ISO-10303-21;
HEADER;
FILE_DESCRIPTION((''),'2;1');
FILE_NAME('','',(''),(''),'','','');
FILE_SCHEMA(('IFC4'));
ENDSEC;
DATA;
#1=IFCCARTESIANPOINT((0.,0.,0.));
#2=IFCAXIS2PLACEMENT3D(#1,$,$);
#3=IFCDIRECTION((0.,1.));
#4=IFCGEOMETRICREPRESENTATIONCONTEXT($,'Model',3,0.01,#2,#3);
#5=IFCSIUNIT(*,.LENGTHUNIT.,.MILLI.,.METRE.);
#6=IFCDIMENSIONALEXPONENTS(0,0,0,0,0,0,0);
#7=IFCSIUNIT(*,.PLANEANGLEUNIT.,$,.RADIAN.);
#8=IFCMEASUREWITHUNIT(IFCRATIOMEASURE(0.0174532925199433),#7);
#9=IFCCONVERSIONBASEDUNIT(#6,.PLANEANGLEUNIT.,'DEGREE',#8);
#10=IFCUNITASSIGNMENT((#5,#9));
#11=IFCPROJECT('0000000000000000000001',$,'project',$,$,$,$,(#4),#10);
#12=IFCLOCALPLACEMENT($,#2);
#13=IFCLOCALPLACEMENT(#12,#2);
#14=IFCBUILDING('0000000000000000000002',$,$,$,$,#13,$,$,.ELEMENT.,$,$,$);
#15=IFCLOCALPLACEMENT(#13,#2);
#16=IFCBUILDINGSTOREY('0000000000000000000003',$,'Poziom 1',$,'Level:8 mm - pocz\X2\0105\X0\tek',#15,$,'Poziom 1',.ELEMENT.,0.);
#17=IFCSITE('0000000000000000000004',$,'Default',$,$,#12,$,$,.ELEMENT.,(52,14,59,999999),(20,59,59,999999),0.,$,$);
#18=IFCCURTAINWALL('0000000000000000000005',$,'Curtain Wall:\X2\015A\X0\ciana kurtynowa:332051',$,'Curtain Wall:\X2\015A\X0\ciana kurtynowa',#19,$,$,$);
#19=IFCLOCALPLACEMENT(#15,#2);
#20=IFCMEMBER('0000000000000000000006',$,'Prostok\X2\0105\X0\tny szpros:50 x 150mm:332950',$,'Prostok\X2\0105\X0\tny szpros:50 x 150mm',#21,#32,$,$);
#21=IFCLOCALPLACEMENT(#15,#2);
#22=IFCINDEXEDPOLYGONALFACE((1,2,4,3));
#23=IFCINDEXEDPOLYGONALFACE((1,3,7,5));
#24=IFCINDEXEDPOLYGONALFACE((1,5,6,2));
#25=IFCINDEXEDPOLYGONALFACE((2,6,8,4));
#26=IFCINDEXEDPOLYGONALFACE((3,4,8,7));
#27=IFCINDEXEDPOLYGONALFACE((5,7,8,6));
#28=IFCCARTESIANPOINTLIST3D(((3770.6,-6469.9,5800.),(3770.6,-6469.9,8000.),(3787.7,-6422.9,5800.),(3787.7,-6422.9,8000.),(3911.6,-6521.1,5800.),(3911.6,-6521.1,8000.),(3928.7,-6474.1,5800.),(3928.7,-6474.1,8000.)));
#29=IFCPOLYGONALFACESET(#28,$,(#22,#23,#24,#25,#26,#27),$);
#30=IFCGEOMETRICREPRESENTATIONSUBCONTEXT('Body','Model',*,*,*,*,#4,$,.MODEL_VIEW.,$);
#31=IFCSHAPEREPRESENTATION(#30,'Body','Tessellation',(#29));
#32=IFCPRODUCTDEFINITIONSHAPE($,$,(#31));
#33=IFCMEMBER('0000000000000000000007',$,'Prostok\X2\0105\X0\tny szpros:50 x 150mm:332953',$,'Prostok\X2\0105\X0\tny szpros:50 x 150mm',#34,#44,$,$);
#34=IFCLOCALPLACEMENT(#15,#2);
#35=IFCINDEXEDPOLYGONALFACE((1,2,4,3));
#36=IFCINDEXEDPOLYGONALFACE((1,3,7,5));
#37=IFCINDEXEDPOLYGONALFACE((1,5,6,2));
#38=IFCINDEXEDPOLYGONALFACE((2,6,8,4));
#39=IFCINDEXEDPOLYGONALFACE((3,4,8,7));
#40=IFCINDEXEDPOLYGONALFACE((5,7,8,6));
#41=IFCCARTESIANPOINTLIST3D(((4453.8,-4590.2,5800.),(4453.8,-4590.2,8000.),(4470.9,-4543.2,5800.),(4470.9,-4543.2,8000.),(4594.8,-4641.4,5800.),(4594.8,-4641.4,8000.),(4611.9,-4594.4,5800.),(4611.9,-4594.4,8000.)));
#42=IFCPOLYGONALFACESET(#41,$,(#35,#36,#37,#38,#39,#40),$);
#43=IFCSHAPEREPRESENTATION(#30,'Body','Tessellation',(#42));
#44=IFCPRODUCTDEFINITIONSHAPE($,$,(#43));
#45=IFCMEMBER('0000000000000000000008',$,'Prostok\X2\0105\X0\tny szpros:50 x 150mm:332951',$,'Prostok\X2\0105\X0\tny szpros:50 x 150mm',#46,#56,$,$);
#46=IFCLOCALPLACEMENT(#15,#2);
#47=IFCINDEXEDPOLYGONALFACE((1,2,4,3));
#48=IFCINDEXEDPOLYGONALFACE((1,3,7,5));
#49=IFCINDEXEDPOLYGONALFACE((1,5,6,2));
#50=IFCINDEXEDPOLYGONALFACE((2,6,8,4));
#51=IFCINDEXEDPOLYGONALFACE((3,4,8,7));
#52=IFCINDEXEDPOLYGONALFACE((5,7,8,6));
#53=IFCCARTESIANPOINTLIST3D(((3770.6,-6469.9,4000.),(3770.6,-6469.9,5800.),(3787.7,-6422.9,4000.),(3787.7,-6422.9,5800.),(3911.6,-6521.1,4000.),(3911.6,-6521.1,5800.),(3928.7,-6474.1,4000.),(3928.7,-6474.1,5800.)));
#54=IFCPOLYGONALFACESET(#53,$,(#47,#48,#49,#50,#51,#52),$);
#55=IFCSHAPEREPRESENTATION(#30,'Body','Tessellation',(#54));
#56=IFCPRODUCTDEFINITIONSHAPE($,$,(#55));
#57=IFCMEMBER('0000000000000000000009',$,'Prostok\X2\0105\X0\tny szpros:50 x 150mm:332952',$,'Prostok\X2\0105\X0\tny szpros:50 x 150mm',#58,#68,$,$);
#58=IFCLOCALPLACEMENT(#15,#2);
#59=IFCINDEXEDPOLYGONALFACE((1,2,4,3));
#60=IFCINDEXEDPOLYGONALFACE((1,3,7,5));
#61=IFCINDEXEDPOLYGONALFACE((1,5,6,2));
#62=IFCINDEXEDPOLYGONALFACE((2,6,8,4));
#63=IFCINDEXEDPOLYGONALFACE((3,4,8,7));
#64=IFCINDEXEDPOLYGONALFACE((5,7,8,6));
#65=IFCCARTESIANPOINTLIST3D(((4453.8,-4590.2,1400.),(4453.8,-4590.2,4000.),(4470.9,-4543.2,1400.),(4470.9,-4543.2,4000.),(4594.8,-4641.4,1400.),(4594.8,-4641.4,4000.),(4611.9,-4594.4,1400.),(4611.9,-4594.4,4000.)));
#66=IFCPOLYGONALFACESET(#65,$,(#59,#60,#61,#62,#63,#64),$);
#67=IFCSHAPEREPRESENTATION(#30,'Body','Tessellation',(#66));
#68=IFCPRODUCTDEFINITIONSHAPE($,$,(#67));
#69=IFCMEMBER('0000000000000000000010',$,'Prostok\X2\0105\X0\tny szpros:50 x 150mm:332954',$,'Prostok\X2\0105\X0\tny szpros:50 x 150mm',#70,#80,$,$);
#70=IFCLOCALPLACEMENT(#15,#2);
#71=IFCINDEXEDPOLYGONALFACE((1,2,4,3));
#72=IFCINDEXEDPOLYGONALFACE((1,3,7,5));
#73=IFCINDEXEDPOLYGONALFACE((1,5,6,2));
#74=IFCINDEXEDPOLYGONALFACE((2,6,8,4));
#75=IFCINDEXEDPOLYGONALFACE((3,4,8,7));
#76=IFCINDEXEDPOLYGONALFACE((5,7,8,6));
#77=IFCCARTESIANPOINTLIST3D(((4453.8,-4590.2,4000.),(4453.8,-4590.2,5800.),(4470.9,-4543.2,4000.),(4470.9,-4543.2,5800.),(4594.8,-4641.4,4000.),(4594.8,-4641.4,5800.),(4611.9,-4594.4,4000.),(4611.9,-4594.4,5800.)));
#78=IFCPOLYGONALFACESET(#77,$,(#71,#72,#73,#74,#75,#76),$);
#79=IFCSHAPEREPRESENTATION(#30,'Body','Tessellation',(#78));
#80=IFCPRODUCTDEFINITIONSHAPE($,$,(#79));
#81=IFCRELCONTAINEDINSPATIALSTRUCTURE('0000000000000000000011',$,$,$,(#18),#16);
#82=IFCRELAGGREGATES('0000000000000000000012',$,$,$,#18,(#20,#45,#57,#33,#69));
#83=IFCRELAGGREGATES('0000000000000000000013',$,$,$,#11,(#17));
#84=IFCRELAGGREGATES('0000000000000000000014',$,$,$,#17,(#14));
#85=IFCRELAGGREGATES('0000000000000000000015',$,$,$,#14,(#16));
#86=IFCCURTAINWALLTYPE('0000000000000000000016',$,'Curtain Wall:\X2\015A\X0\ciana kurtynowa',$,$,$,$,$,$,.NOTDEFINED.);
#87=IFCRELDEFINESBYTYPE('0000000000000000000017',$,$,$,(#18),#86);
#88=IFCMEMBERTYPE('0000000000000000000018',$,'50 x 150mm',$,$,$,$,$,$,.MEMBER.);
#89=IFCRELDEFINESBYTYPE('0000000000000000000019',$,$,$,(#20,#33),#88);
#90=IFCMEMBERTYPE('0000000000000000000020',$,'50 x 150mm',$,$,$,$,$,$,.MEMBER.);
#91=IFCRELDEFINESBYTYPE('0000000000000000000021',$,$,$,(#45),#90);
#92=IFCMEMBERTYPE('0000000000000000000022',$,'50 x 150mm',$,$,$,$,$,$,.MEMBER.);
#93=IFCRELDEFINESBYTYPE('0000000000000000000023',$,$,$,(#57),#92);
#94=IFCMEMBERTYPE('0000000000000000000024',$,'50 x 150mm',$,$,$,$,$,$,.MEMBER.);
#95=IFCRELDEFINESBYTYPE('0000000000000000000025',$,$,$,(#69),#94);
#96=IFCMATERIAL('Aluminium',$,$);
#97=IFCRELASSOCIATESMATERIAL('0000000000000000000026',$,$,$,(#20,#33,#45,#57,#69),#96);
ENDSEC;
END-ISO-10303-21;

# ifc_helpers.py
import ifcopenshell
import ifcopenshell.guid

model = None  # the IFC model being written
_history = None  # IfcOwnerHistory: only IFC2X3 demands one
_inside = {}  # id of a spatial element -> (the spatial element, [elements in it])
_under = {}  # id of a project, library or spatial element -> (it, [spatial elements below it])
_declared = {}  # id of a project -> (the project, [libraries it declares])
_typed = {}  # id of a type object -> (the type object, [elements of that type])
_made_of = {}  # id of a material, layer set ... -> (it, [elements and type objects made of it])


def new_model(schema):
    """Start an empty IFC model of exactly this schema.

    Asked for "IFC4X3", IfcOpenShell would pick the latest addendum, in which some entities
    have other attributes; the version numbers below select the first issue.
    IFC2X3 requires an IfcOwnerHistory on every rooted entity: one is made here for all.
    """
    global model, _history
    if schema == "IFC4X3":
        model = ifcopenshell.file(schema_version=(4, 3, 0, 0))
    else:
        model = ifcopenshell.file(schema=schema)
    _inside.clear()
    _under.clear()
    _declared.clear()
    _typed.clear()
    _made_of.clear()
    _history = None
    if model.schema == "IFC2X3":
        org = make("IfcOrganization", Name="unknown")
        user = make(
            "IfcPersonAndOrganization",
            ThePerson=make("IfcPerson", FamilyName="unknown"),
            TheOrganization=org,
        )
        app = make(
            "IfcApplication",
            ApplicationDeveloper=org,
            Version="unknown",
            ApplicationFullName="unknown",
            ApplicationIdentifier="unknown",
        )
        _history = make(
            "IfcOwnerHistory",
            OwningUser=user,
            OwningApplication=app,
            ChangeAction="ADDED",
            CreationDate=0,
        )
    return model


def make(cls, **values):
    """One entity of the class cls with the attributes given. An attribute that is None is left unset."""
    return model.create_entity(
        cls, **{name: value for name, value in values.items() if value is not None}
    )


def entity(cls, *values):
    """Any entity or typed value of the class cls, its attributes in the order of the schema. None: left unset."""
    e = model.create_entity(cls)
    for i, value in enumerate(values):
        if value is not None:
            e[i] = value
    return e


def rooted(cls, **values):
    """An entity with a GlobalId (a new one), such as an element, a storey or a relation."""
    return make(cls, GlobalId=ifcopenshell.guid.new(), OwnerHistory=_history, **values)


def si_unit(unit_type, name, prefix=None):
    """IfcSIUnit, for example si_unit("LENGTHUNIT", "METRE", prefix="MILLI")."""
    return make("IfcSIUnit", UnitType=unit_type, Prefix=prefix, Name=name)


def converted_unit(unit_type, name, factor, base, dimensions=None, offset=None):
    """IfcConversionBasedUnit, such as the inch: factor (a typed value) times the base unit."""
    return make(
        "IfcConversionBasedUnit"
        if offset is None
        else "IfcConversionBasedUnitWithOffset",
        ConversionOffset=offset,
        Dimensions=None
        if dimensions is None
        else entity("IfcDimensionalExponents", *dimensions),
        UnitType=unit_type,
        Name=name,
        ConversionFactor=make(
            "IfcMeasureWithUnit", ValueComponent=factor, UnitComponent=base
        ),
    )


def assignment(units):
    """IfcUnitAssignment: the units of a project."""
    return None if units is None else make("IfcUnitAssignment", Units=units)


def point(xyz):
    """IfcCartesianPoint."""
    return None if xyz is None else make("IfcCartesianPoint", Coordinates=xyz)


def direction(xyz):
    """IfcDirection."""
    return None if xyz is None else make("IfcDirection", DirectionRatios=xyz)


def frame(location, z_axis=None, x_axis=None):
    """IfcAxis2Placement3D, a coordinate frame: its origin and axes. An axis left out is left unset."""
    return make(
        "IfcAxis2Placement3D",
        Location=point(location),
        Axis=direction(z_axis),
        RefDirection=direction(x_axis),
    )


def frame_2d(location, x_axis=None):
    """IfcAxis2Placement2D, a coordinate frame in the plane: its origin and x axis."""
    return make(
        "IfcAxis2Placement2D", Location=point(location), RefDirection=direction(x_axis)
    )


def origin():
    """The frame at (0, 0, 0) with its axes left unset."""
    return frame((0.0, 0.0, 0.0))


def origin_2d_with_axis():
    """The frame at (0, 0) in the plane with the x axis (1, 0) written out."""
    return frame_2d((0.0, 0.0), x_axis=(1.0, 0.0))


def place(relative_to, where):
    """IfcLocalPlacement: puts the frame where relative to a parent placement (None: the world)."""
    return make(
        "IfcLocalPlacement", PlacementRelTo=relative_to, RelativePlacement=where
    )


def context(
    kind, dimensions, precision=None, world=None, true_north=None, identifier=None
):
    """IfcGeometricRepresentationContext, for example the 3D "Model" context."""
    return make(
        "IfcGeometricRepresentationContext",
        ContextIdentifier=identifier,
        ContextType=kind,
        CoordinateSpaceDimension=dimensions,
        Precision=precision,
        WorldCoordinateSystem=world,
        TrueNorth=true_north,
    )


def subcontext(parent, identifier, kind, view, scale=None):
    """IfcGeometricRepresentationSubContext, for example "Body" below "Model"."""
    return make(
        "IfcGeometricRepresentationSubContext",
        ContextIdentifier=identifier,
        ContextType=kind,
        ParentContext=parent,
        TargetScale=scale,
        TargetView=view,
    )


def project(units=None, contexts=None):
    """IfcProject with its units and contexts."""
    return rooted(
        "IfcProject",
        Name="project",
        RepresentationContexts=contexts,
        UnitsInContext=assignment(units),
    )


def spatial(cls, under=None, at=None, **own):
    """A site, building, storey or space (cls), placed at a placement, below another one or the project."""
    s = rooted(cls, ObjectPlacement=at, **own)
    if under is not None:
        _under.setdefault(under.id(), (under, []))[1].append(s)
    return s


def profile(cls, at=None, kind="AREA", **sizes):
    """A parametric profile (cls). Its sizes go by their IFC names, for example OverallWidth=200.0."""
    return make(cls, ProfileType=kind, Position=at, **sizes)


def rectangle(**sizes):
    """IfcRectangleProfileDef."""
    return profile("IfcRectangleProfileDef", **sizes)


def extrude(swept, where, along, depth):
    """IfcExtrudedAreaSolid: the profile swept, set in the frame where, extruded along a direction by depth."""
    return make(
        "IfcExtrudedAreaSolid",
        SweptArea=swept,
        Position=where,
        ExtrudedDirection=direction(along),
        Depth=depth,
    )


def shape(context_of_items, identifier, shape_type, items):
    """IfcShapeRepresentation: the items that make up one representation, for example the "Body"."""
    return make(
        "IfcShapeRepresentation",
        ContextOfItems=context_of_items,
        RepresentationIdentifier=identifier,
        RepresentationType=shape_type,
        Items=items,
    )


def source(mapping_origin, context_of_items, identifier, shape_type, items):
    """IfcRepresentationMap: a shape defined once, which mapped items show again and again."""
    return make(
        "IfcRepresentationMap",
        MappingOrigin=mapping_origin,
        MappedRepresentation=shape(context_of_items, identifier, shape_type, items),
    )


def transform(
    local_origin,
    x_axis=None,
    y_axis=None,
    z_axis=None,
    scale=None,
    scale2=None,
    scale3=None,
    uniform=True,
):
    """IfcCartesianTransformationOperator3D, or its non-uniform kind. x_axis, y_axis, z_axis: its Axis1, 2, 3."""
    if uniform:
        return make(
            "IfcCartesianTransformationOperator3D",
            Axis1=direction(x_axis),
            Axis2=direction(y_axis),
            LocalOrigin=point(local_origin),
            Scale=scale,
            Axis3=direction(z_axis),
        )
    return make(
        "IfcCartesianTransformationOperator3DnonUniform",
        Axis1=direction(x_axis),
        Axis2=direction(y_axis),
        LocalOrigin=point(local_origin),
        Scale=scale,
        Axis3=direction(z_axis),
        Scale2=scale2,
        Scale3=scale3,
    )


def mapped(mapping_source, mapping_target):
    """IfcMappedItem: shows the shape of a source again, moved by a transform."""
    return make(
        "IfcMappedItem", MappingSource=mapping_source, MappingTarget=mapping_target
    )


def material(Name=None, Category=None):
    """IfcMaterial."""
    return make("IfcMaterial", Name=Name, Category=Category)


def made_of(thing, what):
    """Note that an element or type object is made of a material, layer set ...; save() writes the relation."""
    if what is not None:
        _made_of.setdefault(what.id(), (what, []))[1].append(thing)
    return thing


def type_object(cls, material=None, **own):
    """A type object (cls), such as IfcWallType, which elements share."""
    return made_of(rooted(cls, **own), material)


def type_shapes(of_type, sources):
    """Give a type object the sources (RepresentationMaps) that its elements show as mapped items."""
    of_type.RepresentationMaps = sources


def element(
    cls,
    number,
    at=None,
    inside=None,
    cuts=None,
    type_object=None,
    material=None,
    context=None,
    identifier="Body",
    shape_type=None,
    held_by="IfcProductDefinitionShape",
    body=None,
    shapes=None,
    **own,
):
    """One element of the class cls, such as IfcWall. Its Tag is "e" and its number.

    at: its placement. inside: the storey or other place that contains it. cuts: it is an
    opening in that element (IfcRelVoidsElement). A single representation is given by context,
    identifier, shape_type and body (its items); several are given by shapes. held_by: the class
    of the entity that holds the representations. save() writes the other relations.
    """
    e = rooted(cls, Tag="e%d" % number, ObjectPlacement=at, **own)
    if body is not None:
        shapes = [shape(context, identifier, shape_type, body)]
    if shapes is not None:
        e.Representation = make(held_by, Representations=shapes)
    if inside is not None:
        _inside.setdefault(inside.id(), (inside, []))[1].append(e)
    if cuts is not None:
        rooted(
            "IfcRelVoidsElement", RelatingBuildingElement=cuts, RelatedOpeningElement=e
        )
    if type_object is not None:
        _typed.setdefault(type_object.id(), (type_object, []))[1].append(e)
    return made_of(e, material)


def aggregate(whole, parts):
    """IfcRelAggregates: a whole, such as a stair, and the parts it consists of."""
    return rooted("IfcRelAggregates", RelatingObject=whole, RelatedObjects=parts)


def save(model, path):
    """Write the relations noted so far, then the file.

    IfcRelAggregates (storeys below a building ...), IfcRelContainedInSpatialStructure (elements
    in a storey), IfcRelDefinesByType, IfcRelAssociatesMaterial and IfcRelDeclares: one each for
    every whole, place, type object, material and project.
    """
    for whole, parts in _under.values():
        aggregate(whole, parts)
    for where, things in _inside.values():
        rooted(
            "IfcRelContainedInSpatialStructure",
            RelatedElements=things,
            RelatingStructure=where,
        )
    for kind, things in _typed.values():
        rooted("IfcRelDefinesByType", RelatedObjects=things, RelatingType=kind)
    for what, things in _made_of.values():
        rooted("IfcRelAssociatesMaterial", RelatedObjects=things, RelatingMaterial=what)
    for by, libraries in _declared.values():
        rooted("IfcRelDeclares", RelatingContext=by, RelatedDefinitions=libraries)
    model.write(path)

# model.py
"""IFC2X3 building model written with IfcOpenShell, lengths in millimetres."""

from ifc_helpers import new_model, entity, si_unit, converted_unit, direction, frame, origin, origin_2d_with_axis, place, context, subcontext, project, spatial, rectangle, extrude, source, transform, mapped, material, type_object, type_shapes, element, aggregate, save


model = new_model("IFC2X3")

# Units and contexts
model_context = context("Model", 3, precision=0.01, world=origin(), true_north=direction((0.0, 1.0)))
body_context = subcontext(model_context, "Body", "Model", "MODEL_VIEW")
ifc_project = project(units=[si_unit("LENGTHUNIT", "METRE", prefix="MILLI"), converted_unit("PLANEANGLEUNIT", "DEGREE", entity("IfcRatioMeasure", 0.0174532925199433), si_unit("PLANEANGLEUNIT", "RADIAN"), dimensions=[0, 0, 0, 0, 0, 0, 0])], contexts=[model_context])

# Site, building, storey
site_placement = place(None, origin())
site = spatial("IfcSite", under=ifc_project, at=site_placement, Name="Default", CompositionType="ELEMENT", RefLatitude=(52, 14, 59, 999999), RefLongitude=(20, 59, 59, 999999), RefElevation=0.0)
building_placement = place(site_placement, origin())
building = spatial("IfcBuilding", under=site, at=building_placement, CompositionType="ELEMENT")
storey_placement = place(building_placement, origin())
storey = spatial("IfcBuildingStorey", under=building, at=storey_placement, Name="Poziom 1", ObjectType="Level:8 mm - początek", LongName="Poziom 1", CompositionType="ELEMENT", Elevation=0.0)

# Curtain wall, members
curtain_wall_type = type_object("IfcCurtainWallType", Name="Curtain Wall:Ściana kurtynowa", PredefinedType="NOTDEFINED")
curtain_wall_placement = place(storey_placement, origin())
curtain_wall = element("IfcCurtainWall", 1, at=curtain_wall_placement, inside=storey, type_object=curtain_wall_type, Name="Curtain Wall:Ściana kurtynowa:332051", ObjectType="Curtain Wall:Ściana kurtynowa")
ifc_material_1 = material(Name="Aluminium")
member_type_1 = type_object("IfcMemberType", Name="50 x 150mm", PredefinedType="MEMBER")
shared_shape_1 = source(origin(), body_context, "Body", "SweptSolid", [
    extrude(rectangle(XDim=150.0, YDim=50.0, at=origin_2d_with_axis()), frame((0.0, 0.0, -2200.0), z_axis=(0.0, 0.0, 1.0), x_axis=(0.0, -1.0, 0.0)), (0.0, 0.0, 1.0), 2200.0),
])
type_shapes(member_type_1, [shared_shape_1])
member_1_placement = place(storey_placement, frame((3849.7, -6472.0, 5800.0), z_axis=(0.0, 0.0, -1.0), x_axis=(0.341586, 0.939851, 0.0)))
member_1 = element("IfcMember", 2, at=member_1_placement, type_object=member_type_1, material=ifc_material_1, Name="Prostokątny szpros:50 x 150mm:332950", ObjectType="Prostokątny szpros:50 x 150mm", context=body_context, shape_type="MappedRepresentation", body=[
    mapped(shared_shape_1, transform((0.0, 0.0, 0.0), scale=1.0)),
])
member_2_placement = place(storey_placement, frame((4532.8, -4592.3, 5800.0), z_axis=(0.0, 0.0, -1.0), x_axis=(0.341586, 0.939851, 0.0)))
member_2 = element("IfcMember", 3, at=member_2_placement, type_object=member_type_1, material=ifc_material_1, Name="Prostokątny szpros:50 x 150mm:332953", ObjectType="Prostokątny szpros:50 x 150mm", context=body_context, shape_type="MappedRepresentation", body=[
    mapped(shared_shape_1, transform((0.0, 0.0, 0.0), scale=1.0)),
])
member_type_2 = type_object("IfcMemberType", Name="50 x 150mm", PredefinedType="MEMBER")
shared_shape_2 = source(origin(), body_context, "Body", "SweptSolid", [
    extrude(rectangle(XDim=150.0, YDim=50.0, at=origin_2d_with_axis()), frame((0.0, 0.0, -1800.0), z_axis=(0.0, 0.0, 1.0), x_axis=(0.0, -1.0, 0.0)), (0.0, 0.0, 1.0), 1800.0),
])
type_shapes(member_type_2, [shared_shape_2])
member_3_placement = place(storey_placement, frame((3849.7, -6472.0, 4000.0), z_axis=(0.0, 0.0, -1.0), x_axis=(0.341586, 0.939851, 0.0)))
member_3 = element("IfcMember", 4, at=member_3_placement, type_object=member_type_2, material=ifc_material_1, Name="Prostokątny szpros:50 x 150mm:332951", ObjectType="Prostokątny szpros:50 x 150mm", context=body_context, shape_type="MappedRepresentation", body=[
    mapped(shared_shape_2, transform((0.0, 0.0, 0.0), scale=1.0)),
])
member_type_3 = type_object("IfcMemberType", Name="50 x 150mm", PredefinedType="MEMBER")
shared_shape_3 = source(origin(), body_context, "Body", "SweptSolid", [
    extrude(rectangle(XDim=150.0, YDim=50.0, at=origin_2d_with_axis()), frame((0.0, 0.0, -2600.0), z_axis=(0.0, 0.0, 1.0), x_axis=(0.0, -1.0, 0.0)), (0.0, 0.0, 1.0), 2600.0),
])
type_shapes(member_type_3, [shared_shape_3])
member_4_placement = place(storey_placement, frame((4532.8, -4592.3, 1400.0), z_axis=(0.0, 0.0, -1.0), x_axis=(0.341586, 0.939851, 0.0)))
member_4 = element("IfcMember", 5, at=member_4_placement, type_object=member_type_3, material=ifc_material_1, Name="Prostokątny szpros:50 x 150mm:332952", ObjectType="Prostokątny szpros:50 x 150mm", context=body_context, shape_type="MappedRepresentation", body=[
    mapped(shared_shape_3, transform((0.0, 0.0, 0.0), scale=1.0)),
])
member_type_4 = type_object("IfcMemberType", Name="50 x 150mm", PredefinedType="MEMBER")
shared_shape_4 = source(origin(), body_context, "Body", "SweptSolid", [
    extrude(rectangle(XDim=150.0, YDim=50.0, at=origin_2d_with_axis()), frame((0.0, 0.0, -1800.0), z_axis=(0.0, 0.0, 1.0), x_axis=(0.0, -1.0, 0.0)), (0.0, 0.0, 1.0), 1800.0),
])
type_shapes(member_type_4, [shared_shape_4])
member_5_placement = place(storey_placement, frame((4532.8, -4592.3, 4000.0), z_axis=(0.0, 0.0, -1.0), x_axis=(0.341586, 0.939851, 0.0)))
member_5 = element("IfcMember", 6, at=member_5_placement, type_object=member_type_4, material=ifc_material_1, Name="Prostokątny szpros:50 x 150mm:332954", ObjectType="Prostokątny szpros:50 x 150mm", context=body_context, shape_type="MappedRepresentation", body=[
    mapped(shared_shape_4, transform((0.0, 0.0, 0.0), scale=1.0)),
])
aggregate(curtain_wall, [member_1, member_3, member_4, member_2, member_5])

save(model, "model.ifc")
